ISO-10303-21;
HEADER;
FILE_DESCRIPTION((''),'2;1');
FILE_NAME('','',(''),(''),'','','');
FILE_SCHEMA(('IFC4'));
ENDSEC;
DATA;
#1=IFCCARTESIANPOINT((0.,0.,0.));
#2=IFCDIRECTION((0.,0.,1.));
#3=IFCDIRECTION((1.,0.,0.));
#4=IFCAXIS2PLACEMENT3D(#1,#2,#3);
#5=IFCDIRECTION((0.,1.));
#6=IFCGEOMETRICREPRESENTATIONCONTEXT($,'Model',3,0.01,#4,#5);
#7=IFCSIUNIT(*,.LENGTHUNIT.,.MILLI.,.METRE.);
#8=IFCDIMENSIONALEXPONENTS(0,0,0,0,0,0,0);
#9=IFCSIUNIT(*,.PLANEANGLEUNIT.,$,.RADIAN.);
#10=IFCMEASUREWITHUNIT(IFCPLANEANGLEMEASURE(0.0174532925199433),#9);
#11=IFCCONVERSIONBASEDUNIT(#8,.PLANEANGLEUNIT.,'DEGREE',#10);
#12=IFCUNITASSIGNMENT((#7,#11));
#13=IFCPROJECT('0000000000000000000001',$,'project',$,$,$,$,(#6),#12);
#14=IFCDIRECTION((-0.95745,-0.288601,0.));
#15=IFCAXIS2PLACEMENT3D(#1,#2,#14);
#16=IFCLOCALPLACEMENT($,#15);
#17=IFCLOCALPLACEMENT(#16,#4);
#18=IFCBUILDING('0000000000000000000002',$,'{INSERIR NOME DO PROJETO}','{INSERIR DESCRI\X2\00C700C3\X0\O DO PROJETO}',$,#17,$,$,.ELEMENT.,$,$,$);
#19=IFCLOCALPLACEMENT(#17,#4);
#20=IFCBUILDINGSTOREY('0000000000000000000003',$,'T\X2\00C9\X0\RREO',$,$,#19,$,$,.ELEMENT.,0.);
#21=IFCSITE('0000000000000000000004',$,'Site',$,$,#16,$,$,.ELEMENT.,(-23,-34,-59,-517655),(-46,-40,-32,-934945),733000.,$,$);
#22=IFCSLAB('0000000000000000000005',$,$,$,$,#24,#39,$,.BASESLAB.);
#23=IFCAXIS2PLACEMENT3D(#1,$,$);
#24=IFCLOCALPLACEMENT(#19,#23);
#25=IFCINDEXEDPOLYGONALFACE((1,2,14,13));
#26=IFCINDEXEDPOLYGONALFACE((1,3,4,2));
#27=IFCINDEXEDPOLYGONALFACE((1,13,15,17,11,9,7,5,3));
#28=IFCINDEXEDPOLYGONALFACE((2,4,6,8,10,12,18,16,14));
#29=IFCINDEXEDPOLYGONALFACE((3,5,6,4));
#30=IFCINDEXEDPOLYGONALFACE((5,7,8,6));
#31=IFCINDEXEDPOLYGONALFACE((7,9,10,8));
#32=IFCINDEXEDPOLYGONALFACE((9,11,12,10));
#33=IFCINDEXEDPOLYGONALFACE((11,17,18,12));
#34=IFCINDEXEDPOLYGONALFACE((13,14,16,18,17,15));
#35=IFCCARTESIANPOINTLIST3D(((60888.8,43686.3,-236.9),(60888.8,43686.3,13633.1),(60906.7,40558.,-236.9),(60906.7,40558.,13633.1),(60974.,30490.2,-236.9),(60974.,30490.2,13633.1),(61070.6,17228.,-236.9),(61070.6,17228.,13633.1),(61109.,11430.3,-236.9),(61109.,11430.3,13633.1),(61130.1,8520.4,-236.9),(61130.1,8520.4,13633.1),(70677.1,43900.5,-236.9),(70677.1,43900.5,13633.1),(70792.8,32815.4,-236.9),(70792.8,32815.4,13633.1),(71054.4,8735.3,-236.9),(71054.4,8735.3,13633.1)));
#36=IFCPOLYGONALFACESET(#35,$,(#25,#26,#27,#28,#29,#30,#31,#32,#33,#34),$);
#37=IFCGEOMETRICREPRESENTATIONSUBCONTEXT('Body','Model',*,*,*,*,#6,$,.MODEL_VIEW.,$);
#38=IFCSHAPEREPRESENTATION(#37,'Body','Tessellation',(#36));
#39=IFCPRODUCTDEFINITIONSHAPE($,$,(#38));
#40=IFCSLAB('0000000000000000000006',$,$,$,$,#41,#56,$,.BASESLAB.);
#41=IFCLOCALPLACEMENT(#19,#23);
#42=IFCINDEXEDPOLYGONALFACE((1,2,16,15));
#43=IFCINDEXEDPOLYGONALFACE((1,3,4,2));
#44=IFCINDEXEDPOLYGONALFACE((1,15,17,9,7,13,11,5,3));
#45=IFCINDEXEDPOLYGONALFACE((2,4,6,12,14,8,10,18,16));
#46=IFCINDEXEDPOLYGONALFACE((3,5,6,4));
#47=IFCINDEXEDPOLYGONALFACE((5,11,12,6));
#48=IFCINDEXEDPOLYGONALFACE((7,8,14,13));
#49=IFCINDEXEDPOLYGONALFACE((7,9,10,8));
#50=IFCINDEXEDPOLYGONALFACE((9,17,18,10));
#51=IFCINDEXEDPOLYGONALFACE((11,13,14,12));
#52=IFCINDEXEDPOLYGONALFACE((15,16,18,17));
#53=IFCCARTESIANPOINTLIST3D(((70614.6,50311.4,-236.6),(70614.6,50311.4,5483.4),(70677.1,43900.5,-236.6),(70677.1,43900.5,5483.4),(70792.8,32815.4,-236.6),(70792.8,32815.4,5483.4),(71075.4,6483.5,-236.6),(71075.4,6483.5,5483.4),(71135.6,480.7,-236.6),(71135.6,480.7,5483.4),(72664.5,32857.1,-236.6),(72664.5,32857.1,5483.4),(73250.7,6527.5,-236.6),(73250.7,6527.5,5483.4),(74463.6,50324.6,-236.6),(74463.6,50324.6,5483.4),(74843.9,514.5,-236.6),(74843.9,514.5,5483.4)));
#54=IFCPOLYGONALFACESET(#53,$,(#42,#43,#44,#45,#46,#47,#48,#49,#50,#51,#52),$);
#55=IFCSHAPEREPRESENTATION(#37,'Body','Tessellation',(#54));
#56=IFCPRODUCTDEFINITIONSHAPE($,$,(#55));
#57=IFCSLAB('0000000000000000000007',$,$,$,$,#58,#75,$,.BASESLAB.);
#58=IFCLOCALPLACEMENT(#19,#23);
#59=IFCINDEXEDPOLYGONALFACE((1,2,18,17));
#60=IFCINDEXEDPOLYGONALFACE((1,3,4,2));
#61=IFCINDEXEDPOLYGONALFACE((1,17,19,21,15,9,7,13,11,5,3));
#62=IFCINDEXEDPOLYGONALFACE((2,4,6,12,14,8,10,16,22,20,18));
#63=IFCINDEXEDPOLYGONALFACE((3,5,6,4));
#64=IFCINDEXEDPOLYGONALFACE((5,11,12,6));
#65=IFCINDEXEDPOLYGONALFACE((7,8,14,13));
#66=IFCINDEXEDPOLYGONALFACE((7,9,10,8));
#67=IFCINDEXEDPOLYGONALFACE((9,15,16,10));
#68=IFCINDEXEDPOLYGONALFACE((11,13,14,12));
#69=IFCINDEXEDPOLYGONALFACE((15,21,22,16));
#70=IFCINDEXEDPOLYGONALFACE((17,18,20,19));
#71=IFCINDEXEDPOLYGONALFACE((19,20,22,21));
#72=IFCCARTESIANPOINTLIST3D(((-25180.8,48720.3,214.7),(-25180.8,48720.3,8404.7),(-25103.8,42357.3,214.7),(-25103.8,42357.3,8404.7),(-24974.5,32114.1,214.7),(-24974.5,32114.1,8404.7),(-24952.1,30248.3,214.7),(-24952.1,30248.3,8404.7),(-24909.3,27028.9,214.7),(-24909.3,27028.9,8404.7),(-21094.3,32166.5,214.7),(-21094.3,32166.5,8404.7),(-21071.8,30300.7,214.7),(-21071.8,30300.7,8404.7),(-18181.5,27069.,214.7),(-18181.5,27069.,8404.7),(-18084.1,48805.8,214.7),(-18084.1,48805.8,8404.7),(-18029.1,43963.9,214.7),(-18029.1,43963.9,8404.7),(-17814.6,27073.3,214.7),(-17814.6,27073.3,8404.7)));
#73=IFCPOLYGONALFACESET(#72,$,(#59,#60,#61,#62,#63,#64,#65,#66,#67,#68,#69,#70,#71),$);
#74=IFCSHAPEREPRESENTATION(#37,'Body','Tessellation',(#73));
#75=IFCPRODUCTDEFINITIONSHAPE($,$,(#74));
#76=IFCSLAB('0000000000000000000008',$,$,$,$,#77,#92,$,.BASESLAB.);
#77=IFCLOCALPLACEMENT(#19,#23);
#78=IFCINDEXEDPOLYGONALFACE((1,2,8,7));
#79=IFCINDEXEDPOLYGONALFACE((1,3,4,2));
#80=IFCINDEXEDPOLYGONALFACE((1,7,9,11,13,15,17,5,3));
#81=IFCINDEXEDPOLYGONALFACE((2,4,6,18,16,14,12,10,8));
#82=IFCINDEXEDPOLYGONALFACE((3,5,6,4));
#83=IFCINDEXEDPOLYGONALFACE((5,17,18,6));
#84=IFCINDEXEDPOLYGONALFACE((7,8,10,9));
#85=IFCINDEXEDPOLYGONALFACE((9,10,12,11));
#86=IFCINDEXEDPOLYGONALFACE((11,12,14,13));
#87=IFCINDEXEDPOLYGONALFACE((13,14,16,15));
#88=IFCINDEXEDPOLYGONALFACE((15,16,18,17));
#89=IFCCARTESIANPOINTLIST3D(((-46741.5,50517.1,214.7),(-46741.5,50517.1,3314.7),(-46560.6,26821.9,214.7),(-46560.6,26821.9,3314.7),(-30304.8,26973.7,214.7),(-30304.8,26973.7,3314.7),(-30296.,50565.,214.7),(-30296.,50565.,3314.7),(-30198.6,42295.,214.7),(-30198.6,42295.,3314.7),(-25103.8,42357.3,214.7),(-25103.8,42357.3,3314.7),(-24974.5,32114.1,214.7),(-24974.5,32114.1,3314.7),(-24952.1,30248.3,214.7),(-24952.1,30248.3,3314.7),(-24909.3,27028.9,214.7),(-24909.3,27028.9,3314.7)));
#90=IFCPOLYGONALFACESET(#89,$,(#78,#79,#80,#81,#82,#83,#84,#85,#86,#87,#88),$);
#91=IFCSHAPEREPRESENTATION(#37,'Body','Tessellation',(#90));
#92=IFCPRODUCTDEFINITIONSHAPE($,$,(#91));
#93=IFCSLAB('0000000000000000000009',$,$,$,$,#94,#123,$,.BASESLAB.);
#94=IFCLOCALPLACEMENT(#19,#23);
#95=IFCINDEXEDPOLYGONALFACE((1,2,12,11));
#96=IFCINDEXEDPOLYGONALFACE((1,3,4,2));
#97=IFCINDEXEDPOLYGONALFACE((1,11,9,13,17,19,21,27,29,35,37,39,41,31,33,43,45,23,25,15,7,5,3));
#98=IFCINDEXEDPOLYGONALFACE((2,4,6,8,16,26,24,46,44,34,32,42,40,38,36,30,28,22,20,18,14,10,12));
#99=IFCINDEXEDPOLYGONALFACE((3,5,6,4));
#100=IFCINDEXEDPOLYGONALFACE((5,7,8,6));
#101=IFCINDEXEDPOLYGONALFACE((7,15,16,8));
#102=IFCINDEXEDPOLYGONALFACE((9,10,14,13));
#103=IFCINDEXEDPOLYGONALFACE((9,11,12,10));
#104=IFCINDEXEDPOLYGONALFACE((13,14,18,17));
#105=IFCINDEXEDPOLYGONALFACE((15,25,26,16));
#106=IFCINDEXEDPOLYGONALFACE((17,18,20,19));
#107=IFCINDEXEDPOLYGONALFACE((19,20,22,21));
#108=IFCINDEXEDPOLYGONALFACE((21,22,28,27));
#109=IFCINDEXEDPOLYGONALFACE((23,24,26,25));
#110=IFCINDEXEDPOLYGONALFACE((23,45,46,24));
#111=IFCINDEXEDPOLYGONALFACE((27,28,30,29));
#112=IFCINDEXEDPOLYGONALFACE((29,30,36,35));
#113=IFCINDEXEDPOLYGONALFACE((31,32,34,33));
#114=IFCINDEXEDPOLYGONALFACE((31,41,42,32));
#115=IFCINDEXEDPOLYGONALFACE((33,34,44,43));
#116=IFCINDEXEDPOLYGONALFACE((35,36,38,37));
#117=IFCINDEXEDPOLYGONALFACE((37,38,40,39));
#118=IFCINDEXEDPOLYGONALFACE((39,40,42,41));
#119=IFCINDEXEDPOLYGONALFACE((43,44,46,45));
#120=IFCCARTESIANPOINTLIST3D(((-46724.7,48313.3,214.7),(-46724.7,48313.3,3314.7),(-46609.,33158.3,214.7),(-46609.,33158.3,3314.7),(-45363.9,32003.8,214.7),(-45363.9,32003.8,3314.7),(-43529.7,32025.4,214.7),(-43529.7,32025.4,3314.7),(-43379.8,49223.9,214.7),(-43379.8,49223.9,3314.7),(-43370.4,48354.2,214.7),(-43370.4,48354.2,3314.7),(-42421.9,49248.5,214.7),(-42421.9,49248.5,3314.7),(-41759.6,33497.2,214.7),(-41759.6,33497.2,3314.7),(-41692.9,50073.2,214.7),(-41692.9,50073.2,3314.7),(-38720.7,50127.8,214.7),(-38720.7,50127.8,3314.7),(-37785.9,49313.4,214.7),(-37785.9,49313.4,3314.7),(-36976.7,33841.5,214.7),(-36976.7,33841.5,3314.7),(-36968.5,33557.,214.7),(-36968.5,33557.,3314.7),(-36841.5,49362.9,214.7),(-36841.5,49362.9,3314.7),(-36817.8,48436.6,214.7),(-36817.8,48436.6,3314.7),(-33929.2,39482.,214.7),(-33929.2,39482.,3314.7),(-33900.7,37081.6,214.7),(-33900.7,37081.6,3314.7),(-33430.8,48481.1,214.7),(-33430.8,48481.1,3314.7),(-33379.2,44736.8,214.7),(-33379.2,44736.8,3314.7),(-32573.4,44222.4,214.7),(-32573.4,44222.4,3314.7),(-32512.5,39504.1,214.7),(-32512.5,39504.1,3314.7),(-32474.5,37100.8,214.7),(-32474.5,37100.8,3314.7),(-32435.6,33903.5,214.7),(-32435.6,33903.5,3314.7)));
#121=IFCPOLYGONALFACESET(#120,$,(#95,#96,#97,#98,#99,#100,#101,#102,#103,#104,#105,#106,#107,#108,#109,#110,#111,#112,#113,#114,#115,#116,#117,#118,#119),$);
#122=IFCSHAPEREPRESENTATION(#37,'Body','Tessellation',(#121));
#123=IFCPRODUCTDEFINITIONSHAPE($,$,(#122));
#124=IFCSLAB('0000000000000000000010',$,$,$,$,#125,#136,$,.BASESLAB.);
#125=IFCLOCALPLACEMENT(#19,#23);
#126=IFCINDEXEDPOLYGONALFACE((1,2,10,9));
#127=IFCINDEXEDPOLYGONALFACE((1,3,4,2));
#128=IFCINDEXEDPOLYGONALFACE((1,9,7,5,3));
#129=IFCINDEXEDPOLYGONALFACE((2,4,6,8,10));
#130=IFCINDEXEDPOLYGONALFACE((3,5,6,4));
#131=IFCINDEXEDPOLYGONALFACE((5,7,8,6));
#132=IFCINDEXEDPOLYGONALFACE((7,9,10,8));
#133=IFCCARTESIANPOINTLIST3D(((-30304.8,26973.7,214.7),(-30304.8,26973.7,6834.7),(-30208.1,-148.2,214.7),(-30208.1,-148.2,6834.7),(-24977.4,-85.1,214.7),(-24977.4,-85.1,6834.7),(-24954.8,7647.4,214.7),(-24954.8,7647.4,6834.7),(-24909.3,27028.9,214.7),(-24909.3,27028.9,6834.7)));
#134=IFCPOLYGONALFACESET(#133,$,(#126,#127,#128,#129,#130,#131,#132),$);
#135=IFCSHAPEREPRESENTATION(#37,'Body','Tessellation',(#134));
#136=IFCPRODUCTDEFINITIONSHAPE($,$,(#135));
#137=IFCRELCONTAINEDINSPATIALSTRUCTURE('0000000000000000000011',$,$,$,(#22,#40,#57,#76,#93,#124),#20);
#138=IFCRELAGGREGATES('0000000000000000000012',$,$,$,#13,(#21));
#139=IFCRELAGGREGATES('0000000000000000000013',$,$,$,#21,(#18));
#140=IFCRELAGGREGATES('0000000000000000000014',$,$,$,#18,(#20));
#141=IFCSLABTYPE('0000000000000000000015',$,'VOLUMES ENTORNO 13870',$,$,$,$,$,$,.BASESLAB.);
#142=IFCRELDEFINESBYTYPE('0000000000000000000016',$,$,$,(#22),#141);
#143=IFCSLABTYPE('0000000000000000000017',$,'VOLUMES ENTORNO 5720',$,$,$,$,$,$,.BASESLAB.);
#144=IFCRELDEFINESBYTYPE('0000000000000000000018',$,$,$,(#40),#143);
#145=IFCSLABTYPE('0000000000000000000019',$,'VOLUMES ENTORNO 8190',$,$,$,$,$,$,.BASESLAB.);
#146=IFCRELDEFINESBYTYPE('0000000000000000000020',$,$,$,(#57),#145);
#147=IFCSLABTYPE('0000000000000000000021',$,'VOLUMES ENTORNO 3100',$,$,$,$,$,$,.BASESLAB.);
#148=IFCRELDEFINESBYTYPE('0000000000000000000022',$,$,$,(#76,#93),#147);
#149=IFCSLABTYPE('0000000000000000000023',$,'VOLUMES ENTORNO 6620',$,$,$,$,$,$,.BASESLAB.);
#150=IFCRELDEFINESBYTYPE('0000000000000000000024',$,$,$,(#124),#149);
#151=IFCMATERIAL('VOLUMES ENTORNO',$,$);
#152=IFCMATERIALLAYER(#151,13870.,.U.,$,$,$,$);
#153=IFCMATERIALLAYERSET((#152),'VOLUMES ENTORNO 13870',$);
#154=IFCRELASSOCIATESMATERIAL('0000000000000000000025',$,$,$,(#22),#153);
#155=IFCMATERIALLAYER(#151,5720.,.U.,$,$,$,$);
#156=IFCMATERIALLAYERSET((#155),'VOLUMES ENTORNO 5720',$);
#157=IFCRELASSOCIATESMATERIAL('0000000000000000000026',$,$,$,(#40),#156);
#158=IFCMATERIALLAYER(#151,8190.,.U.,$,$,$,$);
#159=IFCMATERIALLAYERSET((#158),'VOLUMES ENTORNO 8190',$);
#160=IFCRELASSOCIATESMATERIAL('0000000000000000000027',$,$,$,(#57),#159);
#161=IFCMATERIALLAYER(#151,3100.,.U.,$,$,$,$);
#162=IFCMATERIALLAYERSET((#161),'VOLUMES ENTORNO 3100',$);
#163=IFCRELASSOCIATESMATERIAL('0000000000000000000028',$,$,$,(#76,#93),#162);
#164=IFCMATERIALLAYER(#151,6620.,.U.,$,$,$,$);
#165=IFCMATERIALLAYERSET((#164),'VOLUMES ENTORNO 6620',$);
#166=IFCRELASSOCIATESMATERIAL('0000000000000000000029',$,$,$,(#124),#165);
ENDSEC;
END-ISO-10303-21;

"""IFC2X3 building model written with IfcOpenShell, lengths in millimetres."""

from ifc_helpers import new_model, entity, si_unit, converted_unit, direction, frame, origin_with_axes, place, context, subcontext, project, spatial, polyline, outline, extrude, material, layer, layer_set, layer_usage, type_object, element, save


model = new_model("IFC2X3")

# Units and contexts
model_context = context("Model", 3, precision=0.01, world=origin_with_axes(), true_north=direction((0.0, 1.0)))
body_context = subcontext(model_context, "Body", "Model", "MODEL_VIEW")
ifc_project = project(units=[si_unit("LENGTHUNIT", "METRE", prefix="MILLI"), converted_unit("PLANEANGLEUNIT", "DEGREE", entity("IfcPlaneAngleMeasure", 0.0174532925199433), si_unit("PLANEANGLEUNIT", "RADIAN"), dimensions=[0, 0, 0, 0, 0, 0, 0])], contexts=[model_context])

# Site, building, storey
site_placement = place(None, frame((0.0, 0.0, 0.0), z_axis=(0.0, 0.0, 1.0), x_axis=(-0.95745, -0.288601, 0.0)))
site = spatial("IfcSite", under=ifc_project, at=site_placement, Name="Site", CompositionType="ELEMENT", RefLatitude=(-23, -34, -59, -517655), RefLongitude=(-46, -40, -32, -934945), RefElevation=733000.0)
building_placement = place(site_placement, origin_with_axes())
building = spatial("IfcBuilding", under=site, at=building_placement, Name="{INSERIR NOME DO PROJETO}", Description="{INSERIR DESCRIÇÃO DO PROJETO}", CompositionType="ELEMENT")
storey_placement = place(building_placement, origin_with_axes())
storey = spatial("IfcBuildingStorey", under=building, at=storey_placement, Name="TÉRREO", CompositionType="ELEMENT", Elevation=0.0)

# Slabs
ifc_material_1 = material(Name="VOLUMES ENTORNO")
ifc_layer_1 = layer(ifc_material_1, 13870.0, ventilated="UNKNOWN")
ifc_layer_set_1 = layer_set([ifc_layer_1], Name="VOLUMES ENTORNO 13870")
ifc_layer_usage_1 = layer_usage(ifc_layer_set_1, "AXIS3", "NEGATIVE", 13870.0)
slab_type_1 = type_object("IfcSlabType", Name="VOLUMES ENTORNO 13870", PredefinedType="BASESLAB")
slab_1_placement = place(storey_placement, frame((60888.8, 43686.3, -236.9), z_axis=(0.0, 0.0, 1.0), x_axis=(1.0, 0.0, 0.0)))
element("IfcSlab", 1, at=slab_1_placement, inside=storey, type_object=slab_type_1, material=ifc_layer_usage_1, PredefinedType="BASESLAB", context=body_context, shape_type="SweptSolid", body=[
    extrude(outline(polyline([(0.0, 0.0), (17.9, -3128.3), (85.2, -13196.1), (181.9, -26458.3), (220.2, -32256.1), (241.3, -35166.0), (10165.7, -34951.0), (9904.1, -10870.9), (9788.3, 214.2), (0.0, 0.0)])), origin_with_axes(), (0.0, 0.0, 1.0), 13870.0),
])
ifc_layer_2 = layer(ifc_material_1, 5720.0, ventilated="UNKNOWN")
ifc_layer_set_2 = layer_set([ifc_layer_2], Name="VOLUMES ENTORNO 5720")
ifc_layer_usage_2 = layer_usage(ifc_layer_set_2, "AXIS3", "NEGATIVE", 5720.0)
slab_type_2 = type_object("IfcSlabType", Name="VOLUMES ENTORNO 5720", PredefinedType="BASESLAB")
slab_2_placement = place(storey_placement, frame((70614.6, 50311.4, -236.6), z_axis=(0.0, 0.0, 1.0), x_axis=(1.0, 0.0, 0.0)))
element("IfcSlab", 2, at=slab_2_placement, inside=storey, type_object=slab_type_2, material=ifc_layer_usage_2, PredefinedType="BASESLAB", context=body_context, shape_type="SweptSolid", body=[
    extrude(outline(polyline([(0.0, 0.0), (62.5, -6410.8), (178.3, -17495.9), (2049.9, -17454.3), (2636.1, -43783.8), (460.8, -43827.9), (521.0, -49830.7), (4229.3, -49796.8), (3849.0, 13.2), (0.0, 0.0)])), origin_with_axes(), (0.0, 0.0, 1.0), 5720.0),
])
ifc_layer_3 = layer(ifc_material_1, 8190.0, ventilated="UNKNOWN")
ifc_layer_set_3 = layer_set([ifc_layer_3], Name="VOLUMES ENTORNO 8190")
ifc_layer_usage_3 = layer_usage(ifc_layer_set_3, "AXIS3", "NEGATIVE", 8190.0)
slab_type_3 = type_object("IfcSlabType", Name="VOLUMES ENTORNO 8190", PredefinedType="BASESLAB")
slab_3_placement = place(storey_placement, frame((-21094.3, 32166.5, 214.7), z_axis=(0.0, 0.0, 1.0), x_axis=(1.0, 0.0, 0.0)))
element("IfcSlab", 3, at=slab_3_placement, inside=storey, type_object=slab_type_3, material=ifc_layer_usage_3, PredefinedType="BASESLAB", context=body_context, shape_type="SweptSolid", body=[
    extrude(outline(polyline([(0.0, 0.0), (22.5, -1865.9), (-3857.8, -1918.3), (-3815.0, -5137.6), (2912.8, -5097.5), (3279.6, -5093.2), (3065.2, 11797.4), (3010.2, 16639.3), (-4086.5, 16553.7), (-4009.5, 10190.8), (-3880.2, -52.4), (0.0, 0.0)])), origin_with_axes(), (0.0, 0.0, 1.0), 8190.0),
])
ifc_layer_4 = layer(ifc_material_1, 3100.0, ventilated="UNKNOWN")
ifc_layer_set_4 = layer_set([ifc_layer_4], Name="VOLUMES ENTORNO 3100")
ifc_layer_usage_4 = layer_usage(ifc_layer_set_4, "AXIS3", "NEGATIVE", 3100.0)
slab_type_4 = type_object("IfcSlabType", Name="VOLUMES ENTORNO 3100", PredefinedType="BASESLAB")
slab_4_placement = place(storey_placement, frame((-25103.8, 42357.3, 214.7), z_axis=(0.0, 0.0, 1.0), x_axis=(1.0, 0.0, 0.0)))
element("IfcSlab", 4, at=slab_4_placement, inside=storey, type_object=slab_type_4, material=ifc_layer_usage_4, PredefinedType="BASESLAB", context=body_context, shape_type="SweptSolid", body=[
    extrude(outline(polyline([(0.0, 0.0), (-5094.8, -62.3), (-5192.2, 8207.7), (-21637.7, 8159.8), (-21456.8, -15535.4), (-5201.0, -15383.6), (194.5, -15328.4), (151.8, -12109.0), (129.3, -10243.2), (0.0, 0.0)])), origin_with_axes(), (0.0, 0.0, 1.0), 3100.0),
])
ifc_layer_usage_5 = layer_usage(ifc_layer_set_4, "AXIS3", "NEGATIVE", 3100.0)
slab_5_placement = place(storey_placement, frame((-43529.7, 32025.4, 214.7), z_axis=(0.0, 0.0, 1.0), x_axis=(1.0, 0.0, 0.0)))
element("IfcSlab", 5, at=slab_5_placement, inside=storey, type_object=slab_type_4, material=ifc_layer_usage_5, PredefinedType="BASESLAB", context=body_context, shape_type="SweptSolid", body=[
    extrude(outline(polyline([(0.0, 0.0), (1770.1, 1471.8), (6561.2, 1531.6), (6553.0, 1816.1), (11094.1, 1878.2), (11055.2, 5075.4), (9628.9, 5056.2), (9600.5, 7456.6), (11017.1, 7478.7), (10956.3, 12197.0), (10150.4, 12711.5), (10098.8, 16455.7), (6711.9, 16411.2), (6688.2, 17337.5), (5743.7, 17288.0), (4809.0, 18102.4), (1836.8, 18047.8), (1107.8, 17223.2), (149.9, 17198.5), (159.3, 16328.8), (-3195.0, 16287.9), (-3079.3, 1133.0), (-1834.3, -21.5), (0.0, 0.0)])), origin_with_axes(), (0.0, 0.0, 1.0), 3100.0),
])
ifc_layer_5 = layer(ifc_material_1, 6620.0, ventilated="UNKNOWN")
ifc_layer_set_5 = layer_set([ifc_layer_5], Name="VOLUMES ENTORNO 6620")
ifc_layer_usage_6 = layer_usage(ifc_layer_set_5, "AXIS3", "NEGATIVE", 6620.0)
slab_type_5 = type_object("IfcSlabType", Name="VOLUMES ENTORNO 6620", PredefinedType="BASESLAB")
slab_6_placement = place(storey_placement, frame((-24909.3, 27028.9, 214.7), z_axis=(0.0, 0.0, 1.0), x_axis=(1.0, 0.0, 0.0)))
element("IfcSlab", 6, at=slab_6_placement, inside=storey, type_object=slab_type_5, material=ifc_layer_usage_6, PredefinedType="BASESLAB", context=body_context, shape_type="SweptSolid", body=[
    extrude(outline(polyline([(0.0, 0.0), (-5395.5, -55.2), (-5298.8, -27177.2), (-68.0, -27114.1), (-45.5, -19381.6), (0.0, 0.0)])), origin_with_axes(), (0.0, 0.0, 1.0), 6620.0),
])

save(model, "model.ifc")
